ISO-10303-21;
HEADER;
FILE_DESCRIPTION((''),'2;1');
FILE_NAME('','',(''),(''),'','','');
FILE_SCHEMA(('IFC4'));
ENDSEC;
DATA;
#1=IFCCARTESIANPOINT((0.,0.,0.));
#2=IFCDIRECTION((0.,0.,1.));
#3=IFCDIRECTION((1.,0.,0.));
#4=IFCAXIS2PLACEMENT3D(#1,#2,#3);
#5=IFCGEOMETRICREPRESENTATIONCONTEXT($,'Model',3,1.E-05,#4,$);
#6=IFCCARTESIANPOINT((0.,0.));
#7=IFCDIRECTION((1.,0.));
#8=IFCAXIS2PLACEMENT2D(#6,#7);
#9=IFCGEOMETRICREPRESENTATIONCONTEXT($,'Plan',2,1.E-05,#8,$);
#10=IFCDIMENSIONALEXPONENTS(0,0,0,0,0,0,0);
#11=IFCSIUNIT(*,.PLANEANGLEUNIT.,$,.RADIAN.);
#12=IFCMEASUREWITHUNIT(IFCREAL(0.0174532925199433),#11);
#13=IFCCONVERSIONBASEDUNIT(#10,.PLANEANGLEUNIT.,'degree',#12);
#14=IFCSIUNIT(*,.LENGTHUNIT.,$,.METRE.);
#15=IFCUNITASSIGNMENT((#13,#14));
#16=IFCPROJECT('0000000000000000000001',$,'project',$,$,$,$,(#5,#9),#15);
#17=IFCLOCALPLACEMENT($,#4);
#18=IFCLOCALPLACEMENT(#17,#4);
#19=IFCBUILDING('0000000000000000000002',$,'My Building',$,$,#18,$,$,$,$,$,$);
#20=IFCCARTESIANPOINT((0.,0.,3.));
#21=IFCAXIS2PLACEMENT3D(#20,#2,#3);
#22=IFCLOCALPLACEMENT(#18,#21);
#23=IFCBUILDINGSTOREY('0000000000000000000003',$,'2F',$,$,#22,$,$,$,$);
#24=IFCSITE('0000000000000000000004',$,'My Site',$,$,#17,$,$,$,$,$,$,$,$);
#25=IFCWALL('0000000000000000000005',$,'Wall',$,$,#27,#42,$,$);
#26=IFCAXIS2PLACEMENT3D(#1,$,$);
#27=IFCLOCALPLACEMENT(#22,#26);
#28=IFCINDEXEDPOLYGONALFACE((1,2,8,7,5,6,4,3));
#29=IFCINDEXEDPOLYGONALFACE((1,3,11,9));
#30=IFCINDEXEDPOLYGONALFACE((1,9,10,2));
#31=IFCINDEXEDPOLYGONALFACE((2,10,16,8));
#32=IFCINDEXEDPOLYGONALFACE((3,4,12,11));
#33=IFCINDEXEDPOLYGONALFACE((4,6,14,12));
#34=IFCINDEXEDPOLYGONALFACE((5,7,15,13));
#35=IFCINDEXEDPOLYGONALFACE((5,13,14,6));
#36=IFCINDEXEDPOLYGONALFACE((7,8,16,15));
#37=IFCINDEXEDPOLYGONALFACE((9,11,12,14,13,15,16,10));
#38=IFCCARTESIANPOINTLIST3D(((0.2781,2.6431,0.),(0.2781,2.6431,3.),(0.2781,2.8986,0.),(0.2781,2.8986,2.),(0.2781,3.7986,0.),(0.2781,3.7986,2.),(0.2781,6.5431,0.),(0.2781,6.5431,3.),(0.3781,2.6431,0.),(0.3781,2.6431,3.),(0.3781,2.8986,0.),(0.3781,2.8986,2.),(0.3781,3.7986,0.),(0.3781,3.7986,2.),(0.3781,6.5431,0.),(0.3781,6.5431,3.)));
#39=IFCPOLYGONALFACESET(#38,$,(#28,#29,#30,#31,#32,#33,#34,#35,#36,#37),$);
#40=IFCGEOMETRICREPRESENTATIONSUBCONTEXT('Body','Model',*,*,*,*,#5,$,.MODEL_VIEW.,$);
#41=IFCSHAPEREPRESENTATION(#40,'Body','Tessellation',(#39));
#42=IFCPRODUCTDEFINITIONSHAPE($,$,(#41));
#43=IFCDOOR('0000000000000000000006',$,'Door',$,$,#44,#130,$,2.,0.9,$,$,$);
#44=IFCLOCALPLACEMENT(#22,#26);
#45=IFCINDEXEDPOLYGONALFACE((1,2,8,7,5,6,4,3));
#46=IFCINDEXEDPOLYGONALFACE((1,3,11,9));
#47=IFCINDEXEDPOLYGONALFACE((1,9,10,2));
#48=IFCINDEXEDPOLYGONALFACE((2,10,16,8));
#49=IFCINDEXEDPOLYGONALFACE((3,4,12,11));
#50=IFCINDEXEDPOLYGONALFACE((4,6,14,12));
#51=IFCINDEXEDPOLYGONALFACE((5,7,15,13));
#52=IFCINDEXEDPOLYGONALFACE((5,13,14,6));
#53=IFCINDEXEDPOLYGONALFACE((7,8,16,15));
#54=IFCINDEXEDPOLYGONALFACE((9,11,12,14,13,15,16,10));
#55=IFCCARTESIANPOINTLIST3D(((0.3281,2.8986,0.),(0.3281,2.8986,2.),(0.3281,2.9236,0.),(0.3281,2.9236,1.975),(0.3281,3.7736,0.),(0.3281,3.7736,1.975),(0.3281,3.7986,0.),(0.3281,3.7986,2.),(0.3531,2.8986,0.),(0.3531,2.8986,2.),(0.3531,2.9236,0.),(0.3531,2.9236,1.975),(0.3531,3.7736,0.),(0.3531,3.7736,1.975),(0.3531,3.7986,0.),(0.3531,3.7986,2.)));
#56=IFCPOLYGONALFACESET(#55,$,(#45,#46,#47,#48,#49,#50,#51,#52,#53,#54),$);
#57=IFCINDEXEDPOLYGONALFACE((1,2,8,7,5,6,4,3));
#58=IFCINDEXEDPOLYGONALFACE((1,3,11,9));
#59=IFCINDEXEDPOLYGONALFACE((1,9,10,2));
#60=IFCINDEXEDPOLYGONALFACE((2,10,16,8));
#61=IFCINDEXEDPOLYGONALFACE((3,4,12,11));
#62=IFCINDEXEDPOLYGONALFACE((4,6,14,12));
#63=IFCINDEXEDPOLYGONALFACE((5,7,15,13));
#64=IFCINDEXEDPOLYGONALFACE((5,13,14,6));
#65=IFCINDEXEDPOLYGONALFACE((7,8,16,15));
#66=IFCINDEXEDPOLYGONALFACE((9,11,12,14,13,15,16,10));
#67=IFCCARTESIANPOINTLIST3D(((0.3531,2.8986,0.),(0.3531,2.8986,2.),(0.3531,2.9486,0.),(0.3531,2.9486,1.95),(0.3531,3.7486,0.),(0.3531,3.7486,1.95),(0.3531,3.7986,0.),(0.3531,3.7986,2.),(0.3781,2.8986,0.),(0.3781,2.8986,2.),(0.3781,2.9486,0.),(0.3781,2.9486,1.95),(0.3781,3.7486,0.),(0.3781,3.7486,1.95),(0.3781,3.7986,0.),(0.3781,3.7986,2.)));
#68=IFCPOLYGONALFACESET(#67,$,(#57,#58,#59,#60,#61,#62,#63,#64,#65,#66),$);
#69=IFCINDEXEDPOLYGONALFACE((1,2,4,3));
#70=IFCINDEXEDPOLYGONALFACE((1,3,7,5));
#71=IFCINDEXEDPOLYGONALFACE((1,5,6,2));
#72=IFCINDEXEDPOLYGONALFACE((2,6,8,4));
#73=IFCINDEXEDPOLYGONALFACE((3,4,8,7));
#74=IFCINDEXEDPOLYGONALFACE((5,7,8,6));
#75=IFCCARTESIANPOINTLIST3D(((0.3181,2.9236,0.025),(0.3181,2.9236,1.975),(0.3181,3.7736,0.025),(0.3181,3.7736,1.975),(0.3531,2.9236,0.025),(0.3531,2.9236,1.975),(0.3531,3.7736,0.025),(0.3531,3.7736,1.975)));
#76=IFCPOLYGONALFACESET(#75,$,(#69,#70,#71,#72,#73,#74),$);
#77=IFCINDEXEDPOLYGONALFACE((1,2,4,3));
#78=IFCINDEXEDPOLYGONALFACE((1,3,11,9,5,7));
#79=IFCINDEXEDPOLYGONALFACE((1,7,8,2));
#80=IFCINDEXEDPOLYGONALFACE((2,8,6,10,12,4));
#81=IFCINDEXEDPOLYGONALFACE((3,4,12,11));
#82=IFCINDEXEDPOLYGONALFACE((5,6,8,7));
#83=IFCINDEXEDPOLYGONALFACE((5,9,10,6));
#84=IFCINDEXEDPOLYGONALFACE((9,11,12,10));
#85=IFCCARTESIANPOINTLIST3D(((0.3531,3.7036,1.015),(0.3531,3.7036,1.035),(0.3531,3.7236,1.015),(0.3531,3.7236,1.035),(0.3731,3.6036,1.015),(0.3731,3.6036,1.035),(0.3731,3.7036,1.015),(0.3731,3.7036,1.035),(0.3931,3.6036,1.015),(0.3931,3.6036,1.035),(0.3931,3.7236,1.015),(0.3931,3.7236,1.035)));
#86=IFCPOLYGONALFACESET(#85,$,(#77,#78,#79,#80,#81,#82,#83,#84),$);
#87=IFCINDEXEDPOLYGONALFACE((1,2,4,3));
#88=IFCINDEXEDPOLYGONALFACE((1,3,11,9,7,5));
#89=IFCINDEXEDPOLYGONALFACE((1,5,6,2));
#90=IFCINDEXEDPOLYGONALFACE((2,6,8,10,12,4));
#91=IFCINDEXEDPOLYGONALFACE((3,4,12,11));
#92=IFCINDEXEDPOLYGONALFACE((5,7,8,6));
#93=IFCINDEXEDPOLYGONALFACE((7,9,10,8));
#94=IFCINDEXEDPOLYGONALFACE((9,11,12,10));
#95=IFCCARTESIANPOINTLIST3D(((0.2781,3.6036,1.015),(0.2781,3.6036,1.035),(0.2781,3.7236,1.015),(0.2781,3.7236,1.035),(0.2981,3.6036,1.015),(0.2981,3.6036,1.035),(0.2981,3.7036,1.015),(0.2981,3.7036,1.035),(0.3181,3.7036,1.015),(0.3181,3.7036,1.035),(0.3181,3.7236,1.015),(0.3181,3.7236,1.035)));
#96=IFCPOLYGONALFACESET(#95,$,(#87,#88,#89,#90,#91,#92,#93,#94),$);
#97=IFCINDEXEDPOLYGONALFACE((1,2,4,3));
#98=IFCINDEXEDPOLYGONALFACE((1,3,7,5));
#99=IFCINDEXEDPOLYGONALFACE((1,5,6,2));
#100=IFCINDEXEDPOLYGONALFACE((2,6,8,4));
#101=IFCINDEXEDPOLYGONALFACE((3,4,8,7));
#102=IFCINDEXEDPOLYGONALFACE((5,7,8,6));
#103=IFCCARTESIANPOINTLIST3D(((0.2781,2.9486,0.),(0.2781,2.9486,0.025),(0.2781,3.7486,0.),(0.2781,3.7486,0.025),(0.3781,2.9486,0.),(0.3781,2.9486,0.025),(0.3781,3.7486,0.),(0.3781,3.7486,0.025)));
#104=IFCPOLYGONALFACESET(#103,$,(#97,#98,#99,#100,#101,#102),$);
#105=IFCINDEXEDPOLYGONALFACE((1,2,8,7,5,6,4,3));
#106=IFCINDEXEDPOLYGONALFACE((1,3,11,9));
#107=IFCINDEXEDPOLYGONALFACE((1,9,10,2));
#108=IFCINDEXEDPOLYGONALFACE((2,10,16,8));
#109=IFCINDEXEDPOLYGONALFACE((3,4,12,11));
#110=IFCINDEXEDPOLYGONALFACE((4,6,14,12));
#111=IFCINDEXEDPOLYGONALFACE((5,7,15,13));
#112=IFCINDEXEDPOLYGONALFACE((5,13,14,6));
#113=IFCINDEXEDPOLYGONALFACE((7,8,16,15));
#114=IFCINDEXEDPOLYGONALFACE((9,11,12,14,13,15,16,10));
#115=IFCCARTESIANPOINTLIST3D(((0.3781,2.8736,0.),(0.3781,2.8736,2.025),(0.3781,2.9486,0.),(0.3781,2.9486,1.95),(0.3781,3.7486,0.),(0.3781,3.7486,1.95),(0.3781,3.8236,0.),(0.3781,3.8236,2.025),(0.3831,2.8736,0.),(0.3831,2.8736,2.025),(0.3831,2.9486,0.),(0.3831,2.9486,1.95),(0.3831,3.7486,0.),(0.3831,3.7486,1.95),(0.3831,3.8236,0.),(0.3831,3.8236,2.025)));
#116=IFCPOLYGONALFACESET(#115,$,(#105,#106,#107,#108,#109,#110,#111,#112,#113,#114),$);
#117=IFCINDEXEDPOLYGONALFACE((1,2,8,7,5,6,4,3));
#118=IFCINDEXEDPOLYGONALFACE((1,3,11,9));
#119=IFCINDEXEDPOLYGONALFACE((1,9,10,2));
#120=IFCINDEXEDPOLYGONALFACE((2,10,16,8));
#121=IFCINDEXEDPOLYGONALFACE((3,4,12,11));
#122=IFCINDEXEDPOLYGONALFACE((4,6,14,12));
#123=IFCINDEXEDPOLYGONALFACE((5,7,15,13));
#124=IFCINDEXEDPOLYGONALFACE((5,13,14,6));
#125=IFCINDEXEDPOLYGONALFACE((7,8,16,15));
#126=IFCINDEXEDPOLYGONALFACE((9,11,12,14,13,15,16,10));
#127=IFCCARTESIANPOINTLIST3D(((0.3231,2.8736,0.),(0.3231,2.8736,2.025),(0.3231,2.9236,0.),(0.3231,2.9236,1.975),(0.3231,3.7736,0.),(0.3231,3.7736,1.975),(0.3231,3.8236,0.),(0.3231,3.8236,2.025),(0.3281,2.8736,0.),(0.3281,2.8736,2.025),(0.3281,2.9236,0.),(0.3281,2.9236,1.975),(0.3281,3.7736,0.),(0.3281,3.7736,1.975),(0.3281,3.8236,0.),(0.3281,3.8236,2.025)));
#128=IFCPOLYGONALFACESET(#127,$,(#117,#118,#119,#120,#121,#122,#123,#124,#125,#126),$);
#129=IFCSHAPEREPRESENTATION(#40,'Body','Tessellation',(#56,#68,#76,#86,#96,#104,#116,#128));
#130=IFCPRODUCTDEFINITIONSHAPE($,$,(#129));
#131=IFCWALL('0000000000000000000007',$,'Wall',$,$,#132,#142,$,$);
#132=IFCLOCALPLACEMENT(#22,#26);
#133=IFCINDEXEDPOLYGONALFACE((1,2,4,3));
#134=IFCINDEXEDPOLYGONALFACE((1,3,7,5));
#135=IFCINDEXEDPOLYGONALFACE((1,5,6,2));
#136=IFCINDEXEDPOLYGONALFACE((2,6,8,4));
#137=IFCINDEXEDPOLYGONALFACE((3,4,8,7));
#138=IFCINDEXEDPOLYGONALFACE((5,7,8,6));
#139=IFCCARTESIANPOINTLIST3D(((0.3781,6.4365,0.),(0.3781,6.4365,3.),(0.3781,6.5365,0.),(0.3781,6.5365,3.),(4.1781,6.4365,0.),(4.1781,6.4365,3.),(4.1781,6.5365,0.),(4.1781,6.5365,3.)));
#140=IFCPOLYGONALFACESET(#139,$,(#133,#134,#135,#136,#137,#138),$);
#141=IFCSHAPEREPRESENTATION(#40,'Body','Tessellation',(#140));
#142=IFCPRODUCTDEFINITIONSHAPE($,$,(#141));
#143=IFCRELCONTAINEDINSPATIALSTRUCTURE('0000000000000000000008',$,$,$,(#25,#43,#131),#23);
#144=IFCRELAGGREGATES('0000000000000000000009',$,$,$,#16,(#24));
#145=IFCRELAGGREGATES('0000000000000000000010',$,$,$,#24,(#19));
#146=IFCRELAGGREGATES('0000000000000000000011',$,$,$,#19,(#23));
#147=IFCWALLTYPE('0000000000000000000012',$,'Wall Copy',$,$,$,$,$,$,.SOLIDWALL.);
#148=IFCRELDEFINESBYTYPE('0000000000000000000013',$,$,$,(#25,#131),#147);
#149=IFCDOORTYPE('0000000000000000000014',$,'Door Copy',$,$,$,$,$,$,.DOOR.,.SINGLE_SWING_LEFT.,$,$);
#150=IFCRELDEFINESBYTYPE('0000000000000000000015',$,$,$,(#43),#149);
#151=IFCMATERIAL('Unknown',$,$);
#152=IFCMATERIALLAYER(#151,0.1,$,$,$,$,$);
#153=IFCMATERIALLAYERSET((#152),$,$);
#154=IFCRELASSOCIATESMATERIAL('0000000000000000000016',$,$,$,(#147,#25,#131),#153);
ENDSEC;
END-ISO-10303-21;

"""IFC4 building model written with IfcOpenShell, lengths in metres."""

from ifc_helpers import new_model, entity, si_unit, converted_unit, frame, origin_with_axes, origin_2d_with_axis, place, context, subcontext, project, spatial, line, indexed_curve, outline, extrude, shape, source, transform, mapped, material, layer, layer_set, layer_usage, type_object, type_shapes, element, fill, save


model = new_model("IFC4")

# Units and contexts
model_context = context("Model", 3, precision=1e-05, world=origin_with_axes())
plan_context = context("Plan", 2, precision=1e-05, world=origin_2d_with_axis())
body_context_1 = subcontext(model_context, "Body", "Model", "MODEL_VIEW")
body_context_2 = subcontext(plan_context, "Body", "Plan", "PLAN_VIEW")
ifc_project = project(units=[converted_unit("PLANEANGLEUNIT", "degree", entity("IfcReal", 0.0174532925199433), si_unit("PLANEANGLEUNIT", "RADIAN"), dimensions=[0, 0, 0, 0, 0, 0, 0]), si_unit("LENGTHUNIT", "METRE")], contexts=[model_context, plan_context])

# Site, building, storey
site_placement = place(None, origin_with_axes())
site = spatial("IfcSite", under=ifc_project, at=site_placement, Name="My Site")
building_placement = place(site_placement, origin_with_axes())
building = spatial("IfcBuilding", under=site, at=building_placement, Name="My Building")
storey_placement = place(building_placement, frame((0.0, 0.0, 3.0), z_axis=(0.0, 0.0, 1.0), x_axis=(1.0, 0.0, 0.0)))
storey = spatial("IfcBuildingStorey", under=building, at=storey_placement, Name="2F")

# Shared definitions
ifc_material = material(Name="Unknown")

# Shared definitions
ifc_layer_1 = layer(ifc_material, 0.1)
ifc_layer_set_1 = layer_set([ifc_layer_1])
wall_type = type_object("IfcWallType", Name="Wall Copy", PredefinedType="SOLIDWALL", material=ifc_layer_set_1)
shared_shape_1 = source(origin_with_axes(), body_context_1, "Body", "SweptSolid", [
    extrude(outline(indexed_curve([(0.0, 0.0), (0.9, 0.0), (0.9, 2.0), (0.0, 2.0)], segments=[line(1, 2, 3, 4, 1)])), frame((0.0, -0.6, 0.0), z_axis=(0.0, -1.0, 0.0), x_axis=(1.0, 0.0, 0.0)), (0.0, 0.0, -1.0), 1.2),
])
door_type = type_object("IfcDoorType", Name="Door Copy", OperationType="SINGLE_SWING_LEFT", PredefinedType="DOOR")
shared_shape_2 = source(origin_with_axes(), body_context_1, "Body", "SweptSolid", [
    extrude(outline(indexed_curve([(0.0, 0.0), (0.0, 2.0), (0.9, 2.0), (0.9, 0.0), (0.875, 0.0), (0.875, 1.975), (0.025, 1.975), (0.025, 0.0)], segments=[line(1, 2, 3, 4, 5, 6, 7, 8, 1)])), frame((0.0, 0.025, 0.0), z_axis=(0.0, -1.0, 0.0), x_axis=(1.0, 0.0, 0.0)), (0.0, 0.0, -1.0), 0.025),
    extrude(outline(indexed_curve([(0.0, 0.0), (0.0, 2.0), (0.9, 2.0), (0.9, 0.0), (0.85, 0.0), (0.85, 1.95), (0.05, 1.95), (0.05, 0.0)], segments=[line(1, 2, 3, 4, 5, 6, 7, 8, 1)])), frame((0.0, 0.0, 0.0), z_axis=(0.0, -1.0, 0.0), x_axis=(1.0, 0.0, 0.0)), (0.0, 0.0, -1.0), 0.025),
    extrude(outline(indexed_curve([(0.0, 0.0), (0.85, 0.0), (0.85, 0.035), (0.0, 0.035)], segments=[line(1, 2, 3, 4, 1)])), frame((0.025, 0.025, 0.025), z_axis=(0.0, 0.0, 1.0), x_axis=(1.0, 0.0, 0.0)), (0.0, 0.0, 1.0), 1.95),
    extrude(outline(indexed_curve([(0.0, 0.0), (0.0, -0.04), (-0.12, -0.04), (-0.12, -0.02), (-0.02, -0.02), (-0.02, 0.0)], segments=[line(1, 2, 3, 4, 5, 6, 1)])), frame((0.825, 0.025, 1.015), z_axis=(0.0, 0.0, 1.0), x_axis=(1.0, 0.0, 0.0)), (0.0, 0.0, 1.0), 0.02),
    extrude(outline(indexed_curve([(0.0, 0.0), (0.0, 0.04), (-0.12, 0.04), (-0.12, 0.02), (-0.02, 0.02), (-0.02, 0.0)], segments=[line(1, 2, 3, 4, 5, 6, 1)])), frame((0.825, 0.06, 1.015), z_axis=(0.0, 0.0, 1.0), x_axis=(1.0, 0.0, 0.0)), (0.0, 0.0, 1.0), 0.02),
    extrude(outline(indexed_curve([(0.0, 0.0), (0.8, 0.0), (0.8, 0.1), (0.0, 0.1)], segments=[line(1, 2, 3, 4, 1)])), frame((0.05, 0.0, 0.0), z_axis=(0.0, 0.0, 1.0), x_axis=(1.0, 0.0, 0.0)), (0.0, 0.0, 1.0), 0.025),
    extrude(outline(indexed_curve([(0.0, 0.0), (0.0, 2.025), (0.95, 2.025), (0.95, 0.0), (0.875, 0.0), (0.875, 1.95), (0.075, 1.95), (0.075, 0.0)], segments=[line(1, 2, 3, 4, 5, 6, 7, 8, 1)])), frame((-0.025, -0.005, 0.0), z_axis=(0.0, -1.0, 0.0), x_axis=(1.0, 0.0, 0.0)), (0.0, 0.0, -1.0), 0.005),
    extrude(outline(indexed_curve([(0.0, 0.0), (0.0, 2.025), (0.95, 2.025), (0.95, 0.0), (0.9, 0.0), (0.9, 1.975), (0.05, 1.975), (0.05, 0.0)], segments=[line(1, 2, 3, 4, 5, 6, 7, 8, 1)])), frame((-0.025, 0.05, 0.0), z_axis=(0.0, -1.0, 0.0), x_axis=(1.0, 0.0, 0.0)), (0.0, 0.0, -1.0), 0.005),
])
shared_shape_3 = source(origin_with_axes(), body_context_2, "Body", "Curve2D", [
    entity("IfcIndexedPolyCurve", entity("IfcCartesianPointList2D", [[0.0, 0.0], [0.0, 0.05], [0.025, 0.05], [0.025, 0.025], [0.05, 0.025], [0.05, 0.0]]), [entity("IfcLineIndex", [1, 2, 3, 4, 5, 6, 1])]),
    entity("IfcIndexedPolyCurve", entity("IfcCartesianPointList2D", [[0.9, 0.0], [0.9, 0.05], [0.875, 0.05], [0.875, 0.025], [0.85, 0.025], [0.85, 0.0]]), [entity("IfcLineIndex", [1, 2, 3, 4, 5, 6, 1])]),
    entity("IfcTrimmedCurve", entity("IfcEllipse", entity("IfcAxis2Placement2D", entity("IfcCartesianPoint", [0.06, 0.05]), entity("IfcDirection", [1.0, 0.0])), 0.815, 0.85), [entity("IfcCartesianPoint", [0.875, 0.05])], [entity("IfcCartesianPoint", [0.06, 0.9])], True, "CARTESIAN"),
    entity("IfcIndexedPolyCurve", entity("IfcCartesianPointList2D", [[0.025, 0.05], [0.06, 0.05], [0.06, 0.9], [0.025, 0.9]]), [entity("IfcLineIndex", [1, 2, 3, 4, 1])]),
])
type_shapes(door_type, [shared_shape_2, shared_shape_3])

# Wall, opening, door
ifc_layer_usage_1 = layer_usage(ifc_layer_set_1, "AXIS2", "POSITIVE", 0.0)
wall_1_placement = place(storey_placement, frame((0.3781, 2.6431, 0.0), z_axis=(0.0, 0.0, 1.0), x_axis=(0.0, 1.0, 0.0)))
wall_1 = element("IfcWall", 1, at=wall_1_placement, inside=storey, type_object=wall_type, material=ifc_layer_usage_1, Name="Wall", context=body_context_1, shape_type="SweptSolid", body=[
    extrude(outline(indexed_curve([(0.0, 0.0), (0.0, 0.1), (3.9, 0.1), (3.9, 0.0)], segments=[line(1, 2, 3, 4, 1)])), origin_with_axes(), (0.0, 0.0, 1.0), 3.0),
])
opening_1_placement = place(wall_1_placement, frame((0.2554, 0.0, 0.0), z_axis=(0.0, 0.0, 1.0), x_axis=(1.0, 0.0, 0.0)))
opening_1 = element("IfcOpeningElement", 2, at=opening_1_placement, cuts=wall_1, PredefinedType="OPENING", context=body_context_1, shape_type="MappedRepresentation", body=[
    mapped(shared_shape_1, transform((0.0, 0.0, 0.0), x_axis=(1.0, 0.0, 0.0), y_axis=(0.0, 1.0, 0.0), z_axis=(0.0, 0.0, 1.0), scale=1.0)),
])
door_1_placement = place(opening_1_placement, frame((0.0, 0.0, 0.0), z_axis=(0.0, 0.0, 1.0), x_axis=(1.0, 0.0, 0.0)))
door_1 = element("IfcDoor", 3, at=door_1_placement, inside=storey, type_object=door_type, Name="Door", OverallHeight=2.0, OverallWidth=0.9, shapes=[
    shape(body_context_1, "Body", "MappedRepresentation", [mapped(shared_shape_2, transform((0.0, 0.0, 0.0), x_axis=(1.0, 0.0, 0.0), y_axis=(0.0, 1.0, 0.0), z_axis=(0.0, 0.0, 1.0), scale=1.0))]),
    shape(body_context_2, "Body", "MappedRepresentation", [mapped(shared_shape_3, transform((0.0, 0.0, 0.0), x_axis=(1.0, 0.0, 0.0), y_axis=(0.0, 1.0, 0.0), z_axis=(0.0, 0.0, 1.0), scale=1.0))]),
])
fill(opening_1, door_1)

# Wall
ifc_layer_usage_2 = layer_usage(ifc_layer_set_1, "AXIS2", "POSITIVE", 0.0)
wall_2_placement = place(storey_placement, frame((0.3781, 6.4365, 0.0), z_axis=(0.0, 0.0, 1.0), x_axis=(1.0, 0.0, 0.0)))
element("IfcWall", 4, at=wall_2_placement, inside=storey, type_object=wall_type, material=ifc_layer_usage_2, Name="Wall", context=body_context_1, shape_type="SweptSolid", body=[
    extrude(outline(indexed_curve([(0.0, 0.0), (0.0, 0.1), (3.8, 0.1), (3.8, 0.0)], segments=[line(1, 2, 3, 4, 1)])), origin_with_axes(), (0.0, 0.0, 1.0), 3.0),
])

save(model, "model.ifc")
